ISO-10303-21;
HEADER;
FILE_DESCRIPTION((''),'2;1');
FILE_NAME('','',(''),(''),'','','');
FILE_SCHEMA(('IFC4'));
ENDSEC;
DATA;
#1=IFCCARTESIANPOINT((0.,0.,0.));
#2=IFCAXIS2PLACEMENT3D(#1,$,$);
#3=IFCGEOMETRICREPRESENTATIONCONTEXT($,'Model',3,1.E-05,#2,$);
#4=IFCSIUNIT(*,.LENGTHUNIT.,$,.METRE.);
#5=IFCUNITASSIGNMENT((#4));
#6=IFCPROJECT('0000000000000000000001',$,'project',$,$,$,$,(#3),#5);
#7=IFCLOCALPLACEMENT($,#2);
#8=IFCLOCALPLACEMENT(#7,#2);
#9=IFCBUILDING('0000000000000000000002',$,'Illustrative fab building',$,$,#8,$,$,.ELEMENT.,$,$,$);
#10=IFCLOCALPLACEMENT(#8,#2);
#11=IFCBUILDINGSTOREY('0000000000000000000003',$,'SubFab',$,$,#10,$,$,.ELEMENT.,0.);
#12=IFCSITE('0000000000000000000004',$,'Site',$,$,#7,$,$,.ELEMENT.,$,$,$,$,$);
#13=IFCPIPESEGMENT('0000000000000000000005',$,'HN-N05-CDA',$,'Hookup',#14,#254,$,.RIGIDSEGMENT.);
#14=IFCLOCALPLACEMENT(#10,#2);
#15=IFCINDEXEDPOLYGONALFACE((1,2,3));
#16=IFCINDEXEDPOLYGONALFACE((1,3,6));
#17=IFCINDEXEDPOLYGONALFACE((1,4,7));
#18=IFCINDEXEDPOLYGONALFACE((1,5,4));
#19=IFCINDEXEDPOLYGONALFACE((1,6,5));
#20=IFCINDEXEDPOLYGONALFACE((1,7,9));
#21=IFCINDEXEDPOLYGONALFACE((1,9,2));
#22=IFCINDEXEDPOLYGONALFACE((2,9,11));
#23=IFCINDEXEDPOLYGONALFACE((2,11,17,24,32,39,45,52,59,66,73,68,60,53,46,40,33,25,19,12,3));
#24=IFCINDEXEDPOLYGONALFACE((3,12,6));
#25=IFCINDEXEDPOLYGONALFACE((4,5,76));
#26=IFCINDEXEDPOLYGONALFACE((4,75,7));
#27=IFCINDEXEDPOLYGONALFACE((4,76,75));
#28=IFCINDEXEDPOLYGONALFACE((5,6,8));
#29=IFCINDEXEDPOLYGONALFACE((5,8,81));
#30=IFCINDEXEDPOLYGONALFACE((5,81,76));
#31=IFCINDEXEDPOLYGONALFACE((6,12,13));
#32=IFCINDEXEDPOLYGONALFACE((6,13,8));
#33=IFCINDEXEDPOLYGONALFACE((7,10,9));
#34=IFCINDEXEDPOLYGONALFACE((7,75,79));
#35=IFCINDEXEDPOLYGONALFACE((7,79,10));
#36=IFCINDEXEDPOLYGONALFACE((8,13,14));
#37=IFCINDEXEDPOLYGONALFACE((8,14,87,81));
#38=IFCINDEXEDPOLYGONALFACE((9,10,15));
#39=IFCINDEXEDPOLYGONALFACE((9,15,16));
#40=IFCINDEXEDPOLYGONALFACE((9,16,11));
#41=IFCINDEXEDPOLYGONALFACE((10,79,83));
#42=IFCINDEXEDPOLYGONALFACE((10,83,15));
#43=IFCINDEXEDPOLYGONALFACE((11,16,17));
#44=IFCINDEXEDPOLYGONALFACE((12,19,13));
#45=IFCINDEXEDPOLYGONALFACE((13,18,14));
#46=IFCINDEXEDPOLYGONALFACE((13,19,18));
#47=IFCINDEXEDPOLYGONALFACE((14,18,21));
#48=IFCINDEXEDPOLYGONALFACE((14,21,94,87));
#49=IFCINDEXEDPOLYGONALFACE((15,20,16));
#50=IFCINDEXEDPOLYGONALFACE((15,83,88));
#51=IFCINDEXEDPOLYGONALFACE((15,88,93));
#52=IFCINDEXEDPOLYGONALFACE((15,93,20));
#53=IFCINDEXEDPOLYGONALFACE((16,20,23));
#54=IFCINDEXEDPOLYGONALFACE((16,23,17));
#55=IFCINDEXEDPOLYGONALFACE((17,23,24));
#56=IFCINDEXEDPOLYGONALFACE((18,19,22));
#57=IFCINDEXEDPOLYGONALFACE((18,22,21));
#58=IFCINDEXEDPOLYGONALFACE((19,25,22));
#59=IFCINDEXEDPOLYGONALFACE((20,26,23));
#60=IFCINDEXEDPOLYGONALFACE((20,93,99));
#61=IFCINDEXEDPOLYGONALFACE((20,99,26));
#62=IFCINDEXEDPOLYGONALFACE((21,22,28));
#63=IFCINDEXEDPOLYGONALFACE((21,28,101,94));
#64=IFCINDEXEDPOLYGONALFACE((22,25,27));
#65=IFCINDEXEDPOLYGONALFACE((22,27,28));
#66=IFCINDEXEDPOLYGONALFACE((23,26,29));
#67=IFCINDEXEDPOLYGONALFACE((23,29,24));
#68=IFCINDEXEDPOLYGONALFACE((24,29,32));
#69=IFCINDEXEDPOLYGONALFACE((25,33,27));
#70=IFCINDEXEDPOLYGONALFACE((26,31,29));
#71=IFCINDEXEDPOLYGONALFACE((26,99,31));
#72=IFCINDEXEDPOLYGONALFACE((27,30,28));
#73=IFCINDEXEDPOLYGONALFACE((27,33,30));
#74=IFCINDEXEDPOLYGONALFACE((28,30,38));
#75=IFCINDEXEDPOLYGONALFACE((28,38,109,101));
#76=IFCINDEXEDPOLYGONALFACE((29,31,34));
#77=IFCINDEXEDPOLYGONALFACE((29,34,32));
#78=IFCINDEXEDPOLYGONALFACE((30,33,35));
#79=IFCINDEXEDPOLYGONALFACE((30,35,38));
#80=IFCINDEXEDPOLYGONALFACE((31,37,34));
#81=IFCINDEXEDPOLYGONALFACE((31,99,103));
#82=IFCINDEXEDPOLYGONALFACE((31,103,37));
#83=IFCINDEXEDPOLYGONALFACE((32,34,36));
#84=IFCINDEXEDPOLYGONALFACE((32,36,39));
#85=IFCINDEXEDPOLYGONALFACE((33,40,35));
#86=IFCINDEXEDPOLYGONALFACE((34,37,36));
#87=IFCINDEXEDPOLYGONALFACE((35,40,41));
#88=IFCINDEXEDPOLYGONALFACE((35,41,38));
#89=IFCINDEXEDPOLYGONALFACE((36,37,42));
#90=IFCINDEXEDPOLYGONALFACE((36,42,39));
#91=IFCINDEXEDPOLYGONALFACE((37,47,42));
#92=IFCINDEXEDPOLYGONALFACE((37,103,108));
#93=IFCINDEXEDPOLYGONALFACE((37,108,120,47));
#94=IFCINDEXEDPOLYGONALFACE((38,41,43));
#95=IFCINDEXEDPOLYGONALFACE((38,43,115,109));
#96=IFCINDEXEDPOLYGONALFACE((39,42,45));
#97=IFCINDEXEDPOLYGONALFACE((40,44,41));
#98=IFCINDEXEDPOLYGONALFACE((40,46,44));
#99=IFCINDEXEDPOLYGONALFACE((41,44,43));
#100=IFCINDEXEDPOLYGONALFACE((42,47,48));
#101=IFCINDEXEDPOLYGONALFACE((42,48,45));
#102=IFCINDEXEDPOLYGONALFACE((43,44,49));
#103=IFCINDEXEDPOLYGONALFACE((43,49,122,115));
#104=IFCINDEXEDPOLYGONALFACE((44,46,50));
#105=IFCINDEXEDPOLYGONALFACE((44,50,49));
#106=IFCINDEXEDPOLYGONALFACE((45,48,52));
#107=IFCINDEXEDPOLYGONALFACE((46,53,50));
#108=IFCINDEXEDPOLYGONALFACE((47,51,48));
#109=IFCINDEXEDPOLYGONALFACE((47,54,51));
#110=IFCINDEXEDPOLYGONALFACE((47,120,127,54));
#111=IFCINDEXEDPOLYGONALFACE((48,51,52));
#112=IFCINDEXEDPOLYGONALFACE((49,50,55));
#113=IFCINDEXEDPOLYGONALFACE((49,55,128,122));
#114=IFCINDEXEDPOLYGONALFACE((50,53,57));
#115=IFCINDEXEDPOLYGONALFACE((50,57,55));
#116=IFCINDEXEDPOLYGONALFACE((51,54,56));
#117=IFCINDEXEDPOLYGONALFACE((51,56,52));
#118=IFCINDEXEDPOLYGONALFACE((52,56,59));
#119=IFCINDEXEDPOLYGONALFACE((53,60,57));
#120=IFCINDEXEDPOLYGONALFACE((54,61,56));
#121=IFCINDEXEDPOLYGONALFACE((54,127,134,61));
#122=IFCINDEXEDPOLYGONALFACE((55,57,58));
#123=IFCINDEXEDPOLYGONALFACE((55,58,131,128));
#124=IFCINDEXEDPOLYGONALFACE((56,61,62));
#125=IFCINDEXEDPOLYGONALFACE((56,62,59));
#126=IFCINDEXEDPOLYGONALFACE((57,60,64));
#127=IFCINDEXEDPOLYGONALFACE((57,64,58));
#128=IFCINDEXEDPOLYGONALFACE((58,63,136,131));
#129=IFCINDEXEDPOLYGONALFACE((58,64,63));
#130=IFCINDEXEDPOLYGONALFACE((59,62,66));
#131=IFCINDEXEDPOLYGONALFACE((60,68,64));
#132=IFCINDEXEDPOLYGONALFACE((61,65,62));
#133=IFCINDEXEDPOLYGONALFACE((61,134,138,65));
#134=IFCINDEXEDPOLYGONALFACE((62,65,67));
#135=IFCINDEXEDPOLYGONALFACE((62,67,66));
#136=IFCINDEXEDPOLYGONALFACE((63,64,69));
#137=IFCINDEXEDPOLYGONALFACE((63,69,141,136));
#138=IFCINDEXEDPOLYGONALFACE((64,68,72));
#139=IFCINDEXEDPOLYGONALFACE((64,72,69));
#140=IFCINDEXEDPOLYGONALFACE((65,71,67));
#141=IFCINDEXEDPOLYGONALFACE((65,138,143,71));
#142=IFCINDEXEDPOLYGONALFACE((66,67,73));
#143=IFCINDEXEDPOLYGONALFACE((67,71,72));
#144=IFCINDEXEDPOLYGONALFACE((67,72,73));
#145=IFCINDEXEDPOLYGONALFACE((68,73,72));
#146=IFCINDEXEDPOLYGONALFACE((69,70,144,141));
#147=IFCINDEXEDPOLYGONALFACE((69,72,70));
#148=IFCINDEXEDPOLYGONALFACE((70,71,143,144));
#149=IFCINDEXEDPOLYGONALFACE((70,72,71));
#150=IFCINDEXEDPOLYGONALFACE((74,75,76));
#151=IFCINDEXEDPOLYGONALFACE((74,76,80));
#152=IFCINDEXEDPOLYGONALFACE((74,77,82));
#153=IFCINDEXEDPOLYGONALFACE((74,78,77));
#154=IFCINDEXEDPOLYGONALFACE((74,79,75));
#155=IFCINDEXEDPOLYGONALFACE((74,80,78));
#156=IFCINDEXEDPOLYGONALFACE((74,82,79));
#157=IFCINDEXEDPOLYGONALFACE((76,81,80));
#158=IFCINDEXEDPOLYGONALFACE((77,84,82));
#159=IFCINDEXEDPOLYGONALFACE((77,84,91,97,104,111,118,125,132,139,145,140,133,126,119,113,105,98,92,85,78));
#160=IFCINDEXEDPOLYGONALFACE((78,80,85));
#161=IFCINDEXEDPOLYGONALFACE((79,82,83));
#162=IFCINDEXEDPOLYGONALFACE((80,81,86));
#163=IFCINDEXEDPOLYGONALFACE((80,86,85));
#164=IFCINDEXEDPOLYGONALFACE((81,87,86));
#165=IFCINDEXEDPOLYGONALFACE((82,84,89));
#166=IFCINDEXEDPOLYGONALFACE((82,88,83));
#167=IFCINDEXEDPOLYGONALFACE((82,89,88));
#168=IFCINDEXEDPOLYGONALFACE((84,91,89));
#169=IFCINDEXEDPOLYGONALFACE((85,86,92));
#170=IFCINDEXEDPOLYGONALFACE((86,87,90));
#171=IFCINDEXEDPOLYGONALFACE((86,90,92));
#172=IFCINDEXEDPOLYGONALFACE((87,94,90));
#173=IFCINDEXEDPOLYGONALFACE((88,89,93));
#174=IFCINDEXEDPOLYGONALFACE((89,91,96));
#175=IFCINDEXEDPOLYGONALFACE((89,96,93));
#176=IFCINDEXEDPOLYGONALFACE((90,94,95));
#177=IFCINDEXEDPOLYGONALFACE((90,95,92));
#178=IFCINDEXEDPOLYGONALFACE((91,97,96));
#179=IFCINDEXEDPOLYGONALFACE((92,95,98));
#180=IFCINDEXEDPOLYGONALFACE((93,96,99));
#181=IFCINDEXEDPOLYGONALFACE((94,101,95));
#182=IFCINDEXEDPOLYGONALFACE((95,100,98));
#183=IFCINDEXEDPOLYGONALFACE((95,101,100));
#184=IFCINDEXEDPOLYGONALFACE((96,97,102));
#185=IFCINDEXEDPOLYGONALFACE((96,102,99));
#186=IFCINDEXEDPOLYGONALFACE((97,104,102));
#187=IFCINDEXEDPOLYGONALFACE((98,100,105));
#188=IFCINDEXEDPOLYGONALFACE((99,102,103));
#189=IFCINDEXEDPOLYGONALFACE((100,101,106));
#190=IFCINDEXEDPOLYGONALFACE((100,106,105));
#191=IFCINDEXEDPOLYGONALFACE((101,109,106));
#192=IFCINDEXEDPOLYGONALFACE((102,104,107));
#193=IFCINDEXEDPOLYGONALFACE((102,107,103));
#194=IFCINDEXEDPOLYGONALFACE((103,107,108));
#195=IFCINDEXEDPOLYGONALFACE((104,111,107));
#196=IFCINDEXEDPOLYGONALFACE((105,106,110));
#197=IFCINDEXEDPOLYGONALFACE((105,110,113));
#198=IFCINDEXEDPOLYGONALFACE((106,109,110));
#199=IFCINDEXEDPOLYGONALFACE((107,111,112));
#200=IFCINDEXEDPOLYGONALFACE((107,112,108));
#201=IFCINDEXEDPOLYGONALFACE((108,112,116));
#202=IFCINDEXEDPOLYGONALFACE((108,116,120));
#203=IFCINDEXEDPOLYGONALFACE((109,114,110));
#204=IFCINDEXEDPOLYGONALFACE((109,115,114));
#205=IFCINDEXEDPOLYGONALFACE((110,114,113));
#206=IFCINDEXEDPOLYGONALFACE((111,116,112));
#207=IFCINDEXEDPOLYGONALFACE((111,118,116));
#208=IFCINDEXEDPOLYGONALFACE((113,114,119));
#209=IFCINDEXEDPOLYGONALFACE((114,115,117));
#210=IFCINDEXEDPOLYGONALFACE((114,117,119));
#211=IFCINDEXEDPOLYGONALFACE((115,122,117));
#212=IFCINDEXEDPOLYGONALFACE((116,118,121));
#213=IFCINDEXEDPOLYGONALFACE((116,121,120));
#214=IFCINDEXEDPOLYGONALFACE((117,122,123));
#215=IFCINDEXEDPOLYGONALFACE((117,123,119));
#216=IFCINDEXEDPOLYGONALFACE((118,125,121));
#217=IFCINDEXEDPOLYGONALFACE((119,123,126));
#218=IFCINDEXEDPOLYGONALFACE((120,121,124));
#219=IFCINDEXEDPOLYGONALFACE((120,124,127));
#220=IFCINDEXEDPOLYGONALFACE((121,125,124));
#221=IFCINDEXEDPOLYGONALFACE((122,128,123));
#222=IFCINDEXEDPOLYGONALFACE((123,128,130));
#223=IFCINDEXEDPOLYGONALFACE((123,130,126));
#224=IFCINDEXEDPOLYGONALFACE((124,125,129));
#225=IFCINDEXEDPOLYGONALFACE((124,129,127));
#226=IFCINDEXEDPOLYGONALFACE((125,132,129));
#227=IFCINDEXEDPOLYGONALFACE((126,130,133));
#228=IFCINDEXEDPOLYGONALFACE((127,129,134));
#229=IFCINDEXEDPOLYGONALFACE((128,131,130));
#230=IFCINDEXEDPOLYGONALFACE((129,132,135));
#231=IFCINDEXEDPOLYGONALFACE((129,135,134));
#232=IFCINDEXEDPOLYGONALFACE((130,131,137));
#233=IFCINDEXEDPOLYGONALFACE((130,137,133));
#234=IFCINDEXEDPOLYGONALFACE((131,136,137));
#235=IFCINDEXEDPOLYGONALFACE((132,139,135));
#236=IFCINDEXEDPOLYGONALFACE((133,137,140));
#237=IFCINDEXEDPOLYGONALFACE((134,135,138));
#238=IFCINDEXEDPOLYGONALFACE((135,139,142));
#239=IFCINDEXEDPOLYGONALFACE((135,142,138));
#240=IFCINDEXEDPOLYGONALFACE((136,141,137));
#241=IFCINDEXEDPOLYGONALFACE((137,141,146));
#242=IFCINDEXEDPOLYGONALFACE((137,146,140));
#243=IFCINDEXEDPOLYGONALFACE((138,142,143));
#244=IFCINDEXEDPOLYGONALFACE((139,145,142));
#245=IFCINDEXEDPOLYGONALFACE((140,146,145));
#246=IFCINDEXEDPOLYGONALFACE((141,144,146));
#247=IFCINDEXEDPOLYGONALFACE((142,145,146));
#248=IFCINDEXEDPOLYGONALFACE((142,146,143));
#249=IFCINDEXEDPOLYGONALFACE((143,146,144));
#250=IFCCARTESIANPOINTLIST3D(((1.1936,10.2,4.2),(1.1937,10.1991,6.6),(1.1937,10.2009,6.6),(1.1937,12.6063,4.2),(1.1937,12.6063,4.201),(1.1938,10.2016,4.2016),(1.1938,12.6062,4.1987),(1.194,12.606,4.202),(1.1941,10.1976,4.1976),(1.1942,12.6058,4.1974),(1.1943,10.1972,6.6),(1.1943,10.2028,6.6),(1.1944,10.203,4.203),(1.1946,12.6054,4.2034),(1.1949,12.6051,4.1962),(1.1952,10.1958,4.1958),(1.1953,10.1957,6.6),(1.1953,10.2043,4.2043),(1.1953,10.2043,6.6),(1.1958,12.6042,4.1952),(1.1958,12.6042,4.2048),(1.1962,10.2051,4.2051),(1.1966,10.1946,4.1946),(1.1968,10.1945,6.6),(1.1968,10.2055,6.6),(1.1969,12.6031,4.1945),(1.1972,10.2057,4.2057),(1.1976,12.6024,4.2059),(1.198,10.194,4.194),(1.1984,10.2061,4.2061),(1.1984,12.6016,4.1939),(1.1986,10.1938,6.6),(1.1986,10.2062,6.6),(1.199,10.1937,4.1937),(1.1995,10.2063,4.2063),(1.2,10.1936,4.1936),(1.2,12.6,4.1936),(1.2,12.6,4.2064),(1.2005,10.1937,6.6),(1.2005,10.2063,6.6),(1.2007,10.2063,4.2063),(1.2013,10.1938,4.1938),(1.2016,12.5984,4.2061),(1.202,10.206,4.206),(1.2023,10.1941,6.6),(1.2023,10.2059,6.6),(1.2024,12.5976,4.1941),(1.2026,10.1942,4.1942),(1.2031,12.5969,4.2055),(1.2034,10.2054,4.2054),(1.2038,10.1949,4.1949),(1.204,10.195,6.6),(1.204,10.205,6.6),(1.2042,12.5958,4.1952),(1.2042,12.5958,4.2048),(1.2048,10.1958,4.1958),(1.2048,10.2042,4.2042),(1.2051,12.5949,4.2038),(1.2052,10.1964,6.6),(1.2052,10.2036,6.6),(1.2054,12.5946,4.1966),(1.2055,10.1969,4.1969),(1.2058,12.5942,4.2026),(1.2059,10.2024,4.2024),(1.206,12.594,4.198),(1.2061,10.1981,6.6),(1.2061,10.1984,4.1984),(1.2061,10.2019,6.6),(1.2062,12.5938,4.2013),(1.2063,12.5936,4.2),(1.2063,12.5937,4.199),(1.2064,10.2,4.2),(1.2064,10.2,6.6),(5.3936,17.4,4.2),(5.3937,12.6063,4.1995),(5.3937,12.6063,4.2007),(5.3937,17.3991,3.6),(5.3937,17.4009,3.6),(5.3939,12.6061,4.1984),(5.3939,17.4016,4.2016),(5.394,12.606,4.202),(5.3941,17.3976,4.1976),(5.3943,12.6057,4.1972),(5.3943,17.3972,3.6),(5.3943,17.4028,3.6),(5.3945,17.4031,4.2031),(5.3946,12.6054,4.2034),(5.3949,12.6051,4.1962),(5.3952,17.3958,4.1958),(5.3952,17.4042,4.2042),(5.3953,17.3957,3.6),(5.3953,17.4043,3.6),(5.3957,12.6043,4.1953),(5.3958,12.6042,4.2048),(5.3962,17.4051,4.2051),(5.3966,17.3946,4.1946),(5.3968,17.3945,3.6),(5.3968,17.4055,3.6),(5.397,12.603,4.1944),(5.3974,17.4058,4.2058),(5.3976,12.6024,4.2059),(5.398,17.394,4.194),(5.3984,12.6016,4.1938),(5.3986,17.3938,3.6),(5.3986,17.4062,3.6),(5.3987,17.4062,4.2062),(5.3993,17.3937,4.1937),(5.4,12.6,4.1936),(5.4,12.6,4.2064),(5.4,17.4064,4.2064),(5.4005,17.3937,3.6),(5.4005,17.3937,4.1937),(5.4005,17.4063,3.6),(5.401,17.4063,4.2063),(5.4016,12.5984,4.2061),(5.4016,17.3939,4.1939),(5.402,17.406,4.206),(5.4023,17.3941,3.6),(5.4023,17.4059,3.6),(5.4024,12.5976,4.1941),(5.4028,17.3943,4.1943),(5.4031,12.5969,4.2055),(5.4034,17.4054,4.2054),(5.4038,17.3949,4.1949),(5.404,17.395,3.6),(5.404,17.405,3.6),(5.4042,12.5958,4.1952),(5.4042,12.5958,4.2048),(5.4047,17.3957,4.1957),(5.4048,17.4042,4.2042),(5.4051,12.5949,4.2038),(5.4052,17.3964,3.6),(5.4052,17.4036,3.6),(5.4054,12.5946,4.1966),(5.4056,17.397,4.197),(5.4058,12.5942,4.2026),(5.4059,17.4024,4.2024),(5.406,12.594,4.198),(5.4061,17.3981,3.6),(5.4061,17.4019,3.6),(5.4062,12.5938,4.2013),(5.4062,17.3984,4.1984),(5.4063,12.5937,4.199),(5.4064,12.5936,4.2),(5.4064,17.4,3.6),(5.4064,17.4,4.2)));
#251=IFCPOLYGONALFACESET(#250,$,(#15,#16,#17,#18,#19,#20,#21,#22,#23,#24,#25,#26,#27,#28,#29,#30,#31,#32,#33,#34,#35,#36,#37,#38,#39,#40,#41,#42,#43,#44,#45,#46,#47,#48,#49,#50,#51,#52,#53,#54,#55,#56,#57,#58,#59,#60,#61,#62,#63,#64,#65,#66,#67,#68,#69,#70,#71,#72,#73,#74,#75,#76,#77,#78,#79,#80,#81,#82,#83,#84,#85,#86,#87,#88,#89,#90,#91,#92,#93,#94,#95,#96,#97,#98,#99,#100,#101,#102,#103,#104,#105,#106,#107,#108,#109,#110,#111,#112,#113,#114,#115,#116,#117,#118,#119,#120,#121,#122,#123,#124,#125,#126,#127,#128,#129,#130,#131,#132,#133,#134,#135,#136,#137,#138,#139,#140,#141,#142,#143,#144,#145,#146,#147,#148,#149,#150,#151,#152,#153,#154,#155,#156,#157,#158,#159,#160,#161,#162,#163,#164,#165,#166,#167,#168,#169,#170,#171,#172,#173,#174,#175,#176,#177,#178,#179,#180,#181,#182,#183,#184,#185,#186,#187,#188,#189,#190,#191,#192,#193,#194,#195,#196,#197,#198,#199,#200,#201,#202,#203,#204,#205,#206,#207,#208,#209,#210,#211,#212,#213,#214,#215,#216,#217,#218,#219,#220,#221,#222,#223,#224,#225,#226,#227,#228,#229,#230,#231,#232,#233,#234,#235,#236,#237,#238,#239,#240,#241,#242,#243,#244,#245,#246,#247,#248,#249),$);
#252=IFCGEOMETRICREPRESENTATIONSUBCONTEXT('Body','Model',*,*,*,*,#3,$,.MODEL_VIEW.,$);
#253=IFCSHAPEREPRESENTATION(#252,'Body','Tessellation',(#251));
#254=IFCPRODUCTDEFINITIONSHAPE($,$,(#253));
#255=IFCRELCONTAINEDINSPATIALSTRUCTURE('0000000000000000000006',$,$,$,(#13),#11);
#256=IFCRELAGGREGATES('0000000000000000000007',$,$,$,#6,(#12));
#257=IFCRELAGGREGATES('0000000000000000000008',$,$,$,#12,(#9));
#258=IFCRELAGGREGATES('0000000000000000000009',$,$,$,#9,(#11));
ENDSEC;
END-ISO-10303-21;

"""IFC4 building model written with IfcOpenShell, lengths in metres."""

from ifc_helpers import new_model, entity, si_unit, origin, place, context, subcontext, project, spatial, element, save


model = new_model("IFC4")

# Units and contexts
model_context = context("Model", 3, precision=1e-05, world=origin())
body_context = subcontext(model_context, "Body", "Model", "MODEL_VIEW")
ifc_project = project(units=[si_unit("LENGTHUNIT", "METRE")], contexts=[model_context])

# Site, building, storey
site_placement = place(None, origin())
site = spatial("IfcSite", under=ifc_project, at=site_placement, Name="Site", CompositionType="ELEMENT")
building_placement = place(site_placement, origin())
building = spatial("IfcBuilding", under=site, at=building_placement, Name="Illustrative fab building", CompositionType="ELEMENT")
storey_placement = place(building_placement, origin())
storey = spatial("IfcBuildingStorey", under=building, at=storey_placement, Name="SubFab", CompositionType="ELEMENT", Elevation=0.0)

# Pipe segment
pipe_segment_1_placement = place(storey_placement, origin())
element("IfcPipeSegment", 1, at=pipe_segment_1_placement, inside=storey, Name="HN-N05-CDA", ObjectType="Hookup", PredefinedType="RIGIDSEGMENT", context=body_context, shape_type="AdvancedSweptSolid", body=[
    entity("IfcSweptDiskSolid", entity("IfcPolyline", [entity("IfcCartesianPoint", [5.4, 17.4, 3.6]), entity("IfcCartesianPoint", [5.4, 17.4, 4.2]), entity("IfcCartesianPoint", [5.4, 12.6, 4.2]), entity("IfcCartesianPoint", [1.2, 12.6, 4.2]), entity("IfcCartesianPoint", [1.2, 10.2, 4.2]), entity("IfcCartesianPoint", [1.2, 10.2, 6.6])]), 0.0063),
])

save(model, "model.ifc")
